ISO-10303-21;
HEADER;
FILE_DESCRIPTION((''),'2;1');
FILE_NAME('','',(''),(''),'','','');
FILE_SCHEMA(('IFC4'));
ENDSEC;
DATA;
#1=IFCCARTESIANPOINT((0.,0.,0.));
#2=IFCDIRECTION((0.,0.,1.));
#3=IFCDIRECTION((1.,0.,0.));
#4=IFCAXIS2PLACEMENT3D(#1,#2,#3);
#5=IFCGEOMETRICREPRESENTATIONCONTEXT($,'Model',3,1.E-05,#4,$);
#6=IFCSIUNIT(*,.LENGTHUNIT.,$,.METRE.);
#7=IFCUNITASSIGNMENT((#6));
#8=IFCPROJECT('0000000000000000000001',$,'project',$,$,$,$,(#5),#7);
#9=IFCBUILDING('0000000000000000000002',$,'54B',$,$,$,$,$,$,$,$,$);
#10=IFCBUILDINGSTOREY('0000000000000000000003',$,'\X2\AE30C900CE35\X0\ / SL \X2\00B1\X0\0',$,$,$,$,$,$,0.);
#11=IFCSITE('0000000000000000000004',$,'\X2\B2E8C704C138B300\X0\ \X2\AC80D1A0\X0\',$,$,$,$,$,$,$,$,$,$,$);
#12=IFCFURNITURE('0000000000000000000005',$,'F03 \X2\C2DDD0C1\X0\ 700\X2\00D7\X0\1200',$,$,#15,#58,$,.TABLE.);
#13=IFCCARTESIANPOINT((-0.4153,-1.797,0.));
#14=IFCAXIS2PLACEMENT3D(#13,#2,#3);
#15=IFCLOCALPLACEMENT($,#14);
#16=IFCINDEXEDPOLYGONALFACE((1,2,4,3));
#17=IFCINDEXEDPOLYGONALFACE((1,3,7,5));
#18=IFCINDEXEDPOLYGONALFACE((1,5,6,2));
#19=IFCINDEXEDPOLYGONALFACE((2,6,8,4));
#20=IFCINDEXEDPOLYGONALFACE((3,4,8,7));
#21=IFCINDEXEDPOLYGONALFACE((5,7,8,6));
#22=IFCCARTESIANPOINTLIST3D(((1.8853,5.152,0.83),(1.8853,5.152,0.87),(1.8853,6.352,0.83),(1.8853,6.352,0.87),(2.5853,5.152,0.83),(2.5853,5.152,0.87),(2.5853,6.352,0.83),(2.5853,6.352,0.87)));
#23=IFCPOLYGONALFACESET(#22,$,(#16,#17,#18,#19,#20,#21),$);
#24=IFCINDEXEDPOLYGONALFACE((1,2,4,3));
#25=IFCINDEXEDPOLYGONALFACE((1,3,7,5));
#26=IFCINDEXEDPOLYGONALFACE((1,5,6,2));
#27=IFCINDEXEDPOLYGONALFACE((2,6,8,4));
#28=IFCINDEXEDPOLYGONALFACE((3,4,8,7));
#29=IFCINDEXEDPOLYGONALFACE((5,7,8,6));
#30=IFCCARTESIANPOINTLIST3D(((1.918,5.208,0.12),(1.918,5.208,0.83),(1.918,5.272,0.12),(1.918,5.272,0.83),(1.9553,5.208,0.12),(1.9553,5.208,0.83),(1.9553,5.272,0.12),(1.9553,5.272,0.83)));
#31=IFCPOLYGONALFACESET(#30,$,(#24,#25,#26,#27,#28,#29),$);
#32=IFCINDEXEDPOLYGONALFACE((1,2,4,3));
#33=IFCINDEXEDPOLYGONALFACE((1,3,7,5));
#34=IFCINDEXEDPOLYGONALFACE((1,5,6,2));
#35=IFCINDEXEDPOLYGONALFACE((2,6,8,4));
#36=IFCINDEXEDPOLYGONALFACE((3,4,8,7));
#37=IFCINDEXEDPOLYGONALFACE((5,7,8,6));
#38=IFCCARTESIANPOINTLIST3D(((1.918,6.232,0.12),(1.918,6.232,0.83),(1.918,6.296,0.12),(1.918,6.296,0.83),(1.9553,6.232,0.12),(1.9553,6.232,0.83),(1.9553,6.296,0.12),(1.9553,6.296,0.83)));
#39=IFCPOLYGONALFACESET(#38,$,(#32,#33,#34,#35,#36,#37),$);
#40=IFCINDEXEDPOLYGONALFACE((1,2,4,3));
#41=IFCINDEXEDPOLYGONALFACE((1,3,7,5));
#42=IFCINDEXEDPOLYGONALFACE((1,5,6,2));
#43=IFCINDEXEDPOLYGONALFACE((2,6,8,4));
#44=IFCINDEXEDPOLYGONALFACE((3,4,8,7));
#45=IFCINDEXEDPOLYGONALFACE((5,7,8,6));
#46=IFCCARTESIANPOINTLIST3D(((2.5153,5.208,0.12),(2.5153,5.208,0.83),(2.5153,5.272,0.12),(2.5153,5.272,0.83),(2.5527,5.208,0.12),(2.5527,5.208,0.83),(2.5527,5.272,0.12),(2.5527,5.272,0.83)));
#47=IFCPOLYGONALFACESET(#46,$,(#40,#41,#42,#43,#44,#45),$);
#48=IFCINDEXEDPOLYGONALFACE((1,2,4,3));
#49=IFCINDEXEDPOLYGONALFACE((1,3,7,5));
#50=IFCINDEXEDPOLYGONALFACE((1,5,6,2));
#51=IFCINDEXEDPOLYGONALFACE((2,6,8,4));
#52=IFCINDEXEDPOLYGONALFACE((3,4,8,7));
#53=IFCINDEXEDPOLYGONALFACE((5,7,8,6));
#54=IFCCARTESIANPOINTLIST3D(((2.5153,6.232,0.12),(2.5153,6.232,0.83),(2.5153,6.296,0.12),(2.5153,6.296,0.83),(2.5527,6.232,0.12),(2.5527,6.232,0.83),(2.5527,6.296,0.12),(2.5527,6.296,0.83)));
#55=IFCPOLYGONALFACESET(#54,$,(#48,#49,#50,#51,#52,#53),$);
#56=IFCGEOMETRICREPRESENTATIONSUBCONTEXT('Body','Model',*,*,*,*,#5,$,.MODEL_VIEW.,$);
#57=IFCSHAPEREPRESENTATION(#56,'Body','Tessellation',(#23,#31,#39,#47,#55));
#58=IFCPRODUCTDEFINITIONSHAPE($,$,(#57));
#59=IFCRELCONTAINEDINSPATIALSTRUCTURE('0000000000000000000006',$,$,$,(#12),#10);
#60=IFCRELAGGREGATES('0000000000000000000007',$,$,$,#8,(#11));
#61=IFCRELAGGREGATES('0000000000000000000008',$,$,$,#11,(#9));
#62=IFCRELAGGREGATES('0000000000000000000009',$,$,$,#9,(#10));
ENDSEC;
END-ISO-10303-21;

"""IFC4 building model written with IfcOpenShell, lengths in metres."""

from ifc_helpers import new_model, si_unit, frame, origin_with_axes, place, context, subcontext, project, spatial, polyline, outline, extrude, element, save


model = new_model("IFC4")

# Units and contexts
model_context = context("Model", 3, precision=1e-05, world=origin_with_axes())
body_context = subcontext(model_context, "Body", "Model", "MODEL_VIEW")
ifc_project = project(units=[si_unit("LENGTHUNIT", "METRE")], contexts=[model_context])

# Site, building, storey
site = spatial("IfcSite", under=ifc_project, Name="단위세대 검토")
building = spatial("IfcBuilding", under=site, Name="54B")
storey = spatial("IfcBuildingStorey", under=building, Name="기준층 / SL ±0", Elevation=0.0)

# Furniture
furniture_placement = place(None, frame((-0.4153, -1.797, 0.0), z_axis=(0.0, 0.0, 1.0), x_axis=(1.0, 0.0, 0.0)))
element("IfcFurniture", 1, at=furniture_placement, inside=storey, Name="F03 식탁 700×1200", PredefinedType="TABLE", context=body_context, shape_type="SweptSolid", body=[
    extrude(outline(polyline([(2.5853, 6.352), (2.5853, 5.152), (1.8853, 5.152), (1.8853, 6.352), (2.5853, 6.352)])), frame((0.0, 0.0, 0.83)), (0.0, 0.0, 1.0), 0.04),
    extrude(outline(polyline([(1.9553, 5.208), (1.9553, 5.272), (1.918, 5.272), (1.918, 5.208), (1.9553, 5.208)])), frame((0.0, 0.0, 0.12)), (0.0, 0.0, 1.0), 0.71),
    extrude(outline(polyline([(1.9553, 6.232), (1.9553, 6.296), (1.918, 6.296), (1.918, 6.232), (1.9553, 6.232)])), frame((0.0, 0.0, 0.12)), (0.0, 0.0, 1.0), 0.71),
    extrude(outline(polyline([(2.5527, 5.208), (2.5527, 5.272), (2.5153, 5.272), (2.5153, 5.208), (2.5527, 5.208)])), frame((0.0, 0.0, 0.12)), (0.0, 0.0, 1.0), 0.71),
    extrude(outline(polyline([(2.5527, 6.232), (2.5527, 6.296), (2.5153, 6.296), (2.5153, 6.232), (2.5527, 6.232)])), frame((0.0, 0.0, 0.12)), (0.0, 0.0, 1.0), 0.71),
])

save(model, "model.ifc")
